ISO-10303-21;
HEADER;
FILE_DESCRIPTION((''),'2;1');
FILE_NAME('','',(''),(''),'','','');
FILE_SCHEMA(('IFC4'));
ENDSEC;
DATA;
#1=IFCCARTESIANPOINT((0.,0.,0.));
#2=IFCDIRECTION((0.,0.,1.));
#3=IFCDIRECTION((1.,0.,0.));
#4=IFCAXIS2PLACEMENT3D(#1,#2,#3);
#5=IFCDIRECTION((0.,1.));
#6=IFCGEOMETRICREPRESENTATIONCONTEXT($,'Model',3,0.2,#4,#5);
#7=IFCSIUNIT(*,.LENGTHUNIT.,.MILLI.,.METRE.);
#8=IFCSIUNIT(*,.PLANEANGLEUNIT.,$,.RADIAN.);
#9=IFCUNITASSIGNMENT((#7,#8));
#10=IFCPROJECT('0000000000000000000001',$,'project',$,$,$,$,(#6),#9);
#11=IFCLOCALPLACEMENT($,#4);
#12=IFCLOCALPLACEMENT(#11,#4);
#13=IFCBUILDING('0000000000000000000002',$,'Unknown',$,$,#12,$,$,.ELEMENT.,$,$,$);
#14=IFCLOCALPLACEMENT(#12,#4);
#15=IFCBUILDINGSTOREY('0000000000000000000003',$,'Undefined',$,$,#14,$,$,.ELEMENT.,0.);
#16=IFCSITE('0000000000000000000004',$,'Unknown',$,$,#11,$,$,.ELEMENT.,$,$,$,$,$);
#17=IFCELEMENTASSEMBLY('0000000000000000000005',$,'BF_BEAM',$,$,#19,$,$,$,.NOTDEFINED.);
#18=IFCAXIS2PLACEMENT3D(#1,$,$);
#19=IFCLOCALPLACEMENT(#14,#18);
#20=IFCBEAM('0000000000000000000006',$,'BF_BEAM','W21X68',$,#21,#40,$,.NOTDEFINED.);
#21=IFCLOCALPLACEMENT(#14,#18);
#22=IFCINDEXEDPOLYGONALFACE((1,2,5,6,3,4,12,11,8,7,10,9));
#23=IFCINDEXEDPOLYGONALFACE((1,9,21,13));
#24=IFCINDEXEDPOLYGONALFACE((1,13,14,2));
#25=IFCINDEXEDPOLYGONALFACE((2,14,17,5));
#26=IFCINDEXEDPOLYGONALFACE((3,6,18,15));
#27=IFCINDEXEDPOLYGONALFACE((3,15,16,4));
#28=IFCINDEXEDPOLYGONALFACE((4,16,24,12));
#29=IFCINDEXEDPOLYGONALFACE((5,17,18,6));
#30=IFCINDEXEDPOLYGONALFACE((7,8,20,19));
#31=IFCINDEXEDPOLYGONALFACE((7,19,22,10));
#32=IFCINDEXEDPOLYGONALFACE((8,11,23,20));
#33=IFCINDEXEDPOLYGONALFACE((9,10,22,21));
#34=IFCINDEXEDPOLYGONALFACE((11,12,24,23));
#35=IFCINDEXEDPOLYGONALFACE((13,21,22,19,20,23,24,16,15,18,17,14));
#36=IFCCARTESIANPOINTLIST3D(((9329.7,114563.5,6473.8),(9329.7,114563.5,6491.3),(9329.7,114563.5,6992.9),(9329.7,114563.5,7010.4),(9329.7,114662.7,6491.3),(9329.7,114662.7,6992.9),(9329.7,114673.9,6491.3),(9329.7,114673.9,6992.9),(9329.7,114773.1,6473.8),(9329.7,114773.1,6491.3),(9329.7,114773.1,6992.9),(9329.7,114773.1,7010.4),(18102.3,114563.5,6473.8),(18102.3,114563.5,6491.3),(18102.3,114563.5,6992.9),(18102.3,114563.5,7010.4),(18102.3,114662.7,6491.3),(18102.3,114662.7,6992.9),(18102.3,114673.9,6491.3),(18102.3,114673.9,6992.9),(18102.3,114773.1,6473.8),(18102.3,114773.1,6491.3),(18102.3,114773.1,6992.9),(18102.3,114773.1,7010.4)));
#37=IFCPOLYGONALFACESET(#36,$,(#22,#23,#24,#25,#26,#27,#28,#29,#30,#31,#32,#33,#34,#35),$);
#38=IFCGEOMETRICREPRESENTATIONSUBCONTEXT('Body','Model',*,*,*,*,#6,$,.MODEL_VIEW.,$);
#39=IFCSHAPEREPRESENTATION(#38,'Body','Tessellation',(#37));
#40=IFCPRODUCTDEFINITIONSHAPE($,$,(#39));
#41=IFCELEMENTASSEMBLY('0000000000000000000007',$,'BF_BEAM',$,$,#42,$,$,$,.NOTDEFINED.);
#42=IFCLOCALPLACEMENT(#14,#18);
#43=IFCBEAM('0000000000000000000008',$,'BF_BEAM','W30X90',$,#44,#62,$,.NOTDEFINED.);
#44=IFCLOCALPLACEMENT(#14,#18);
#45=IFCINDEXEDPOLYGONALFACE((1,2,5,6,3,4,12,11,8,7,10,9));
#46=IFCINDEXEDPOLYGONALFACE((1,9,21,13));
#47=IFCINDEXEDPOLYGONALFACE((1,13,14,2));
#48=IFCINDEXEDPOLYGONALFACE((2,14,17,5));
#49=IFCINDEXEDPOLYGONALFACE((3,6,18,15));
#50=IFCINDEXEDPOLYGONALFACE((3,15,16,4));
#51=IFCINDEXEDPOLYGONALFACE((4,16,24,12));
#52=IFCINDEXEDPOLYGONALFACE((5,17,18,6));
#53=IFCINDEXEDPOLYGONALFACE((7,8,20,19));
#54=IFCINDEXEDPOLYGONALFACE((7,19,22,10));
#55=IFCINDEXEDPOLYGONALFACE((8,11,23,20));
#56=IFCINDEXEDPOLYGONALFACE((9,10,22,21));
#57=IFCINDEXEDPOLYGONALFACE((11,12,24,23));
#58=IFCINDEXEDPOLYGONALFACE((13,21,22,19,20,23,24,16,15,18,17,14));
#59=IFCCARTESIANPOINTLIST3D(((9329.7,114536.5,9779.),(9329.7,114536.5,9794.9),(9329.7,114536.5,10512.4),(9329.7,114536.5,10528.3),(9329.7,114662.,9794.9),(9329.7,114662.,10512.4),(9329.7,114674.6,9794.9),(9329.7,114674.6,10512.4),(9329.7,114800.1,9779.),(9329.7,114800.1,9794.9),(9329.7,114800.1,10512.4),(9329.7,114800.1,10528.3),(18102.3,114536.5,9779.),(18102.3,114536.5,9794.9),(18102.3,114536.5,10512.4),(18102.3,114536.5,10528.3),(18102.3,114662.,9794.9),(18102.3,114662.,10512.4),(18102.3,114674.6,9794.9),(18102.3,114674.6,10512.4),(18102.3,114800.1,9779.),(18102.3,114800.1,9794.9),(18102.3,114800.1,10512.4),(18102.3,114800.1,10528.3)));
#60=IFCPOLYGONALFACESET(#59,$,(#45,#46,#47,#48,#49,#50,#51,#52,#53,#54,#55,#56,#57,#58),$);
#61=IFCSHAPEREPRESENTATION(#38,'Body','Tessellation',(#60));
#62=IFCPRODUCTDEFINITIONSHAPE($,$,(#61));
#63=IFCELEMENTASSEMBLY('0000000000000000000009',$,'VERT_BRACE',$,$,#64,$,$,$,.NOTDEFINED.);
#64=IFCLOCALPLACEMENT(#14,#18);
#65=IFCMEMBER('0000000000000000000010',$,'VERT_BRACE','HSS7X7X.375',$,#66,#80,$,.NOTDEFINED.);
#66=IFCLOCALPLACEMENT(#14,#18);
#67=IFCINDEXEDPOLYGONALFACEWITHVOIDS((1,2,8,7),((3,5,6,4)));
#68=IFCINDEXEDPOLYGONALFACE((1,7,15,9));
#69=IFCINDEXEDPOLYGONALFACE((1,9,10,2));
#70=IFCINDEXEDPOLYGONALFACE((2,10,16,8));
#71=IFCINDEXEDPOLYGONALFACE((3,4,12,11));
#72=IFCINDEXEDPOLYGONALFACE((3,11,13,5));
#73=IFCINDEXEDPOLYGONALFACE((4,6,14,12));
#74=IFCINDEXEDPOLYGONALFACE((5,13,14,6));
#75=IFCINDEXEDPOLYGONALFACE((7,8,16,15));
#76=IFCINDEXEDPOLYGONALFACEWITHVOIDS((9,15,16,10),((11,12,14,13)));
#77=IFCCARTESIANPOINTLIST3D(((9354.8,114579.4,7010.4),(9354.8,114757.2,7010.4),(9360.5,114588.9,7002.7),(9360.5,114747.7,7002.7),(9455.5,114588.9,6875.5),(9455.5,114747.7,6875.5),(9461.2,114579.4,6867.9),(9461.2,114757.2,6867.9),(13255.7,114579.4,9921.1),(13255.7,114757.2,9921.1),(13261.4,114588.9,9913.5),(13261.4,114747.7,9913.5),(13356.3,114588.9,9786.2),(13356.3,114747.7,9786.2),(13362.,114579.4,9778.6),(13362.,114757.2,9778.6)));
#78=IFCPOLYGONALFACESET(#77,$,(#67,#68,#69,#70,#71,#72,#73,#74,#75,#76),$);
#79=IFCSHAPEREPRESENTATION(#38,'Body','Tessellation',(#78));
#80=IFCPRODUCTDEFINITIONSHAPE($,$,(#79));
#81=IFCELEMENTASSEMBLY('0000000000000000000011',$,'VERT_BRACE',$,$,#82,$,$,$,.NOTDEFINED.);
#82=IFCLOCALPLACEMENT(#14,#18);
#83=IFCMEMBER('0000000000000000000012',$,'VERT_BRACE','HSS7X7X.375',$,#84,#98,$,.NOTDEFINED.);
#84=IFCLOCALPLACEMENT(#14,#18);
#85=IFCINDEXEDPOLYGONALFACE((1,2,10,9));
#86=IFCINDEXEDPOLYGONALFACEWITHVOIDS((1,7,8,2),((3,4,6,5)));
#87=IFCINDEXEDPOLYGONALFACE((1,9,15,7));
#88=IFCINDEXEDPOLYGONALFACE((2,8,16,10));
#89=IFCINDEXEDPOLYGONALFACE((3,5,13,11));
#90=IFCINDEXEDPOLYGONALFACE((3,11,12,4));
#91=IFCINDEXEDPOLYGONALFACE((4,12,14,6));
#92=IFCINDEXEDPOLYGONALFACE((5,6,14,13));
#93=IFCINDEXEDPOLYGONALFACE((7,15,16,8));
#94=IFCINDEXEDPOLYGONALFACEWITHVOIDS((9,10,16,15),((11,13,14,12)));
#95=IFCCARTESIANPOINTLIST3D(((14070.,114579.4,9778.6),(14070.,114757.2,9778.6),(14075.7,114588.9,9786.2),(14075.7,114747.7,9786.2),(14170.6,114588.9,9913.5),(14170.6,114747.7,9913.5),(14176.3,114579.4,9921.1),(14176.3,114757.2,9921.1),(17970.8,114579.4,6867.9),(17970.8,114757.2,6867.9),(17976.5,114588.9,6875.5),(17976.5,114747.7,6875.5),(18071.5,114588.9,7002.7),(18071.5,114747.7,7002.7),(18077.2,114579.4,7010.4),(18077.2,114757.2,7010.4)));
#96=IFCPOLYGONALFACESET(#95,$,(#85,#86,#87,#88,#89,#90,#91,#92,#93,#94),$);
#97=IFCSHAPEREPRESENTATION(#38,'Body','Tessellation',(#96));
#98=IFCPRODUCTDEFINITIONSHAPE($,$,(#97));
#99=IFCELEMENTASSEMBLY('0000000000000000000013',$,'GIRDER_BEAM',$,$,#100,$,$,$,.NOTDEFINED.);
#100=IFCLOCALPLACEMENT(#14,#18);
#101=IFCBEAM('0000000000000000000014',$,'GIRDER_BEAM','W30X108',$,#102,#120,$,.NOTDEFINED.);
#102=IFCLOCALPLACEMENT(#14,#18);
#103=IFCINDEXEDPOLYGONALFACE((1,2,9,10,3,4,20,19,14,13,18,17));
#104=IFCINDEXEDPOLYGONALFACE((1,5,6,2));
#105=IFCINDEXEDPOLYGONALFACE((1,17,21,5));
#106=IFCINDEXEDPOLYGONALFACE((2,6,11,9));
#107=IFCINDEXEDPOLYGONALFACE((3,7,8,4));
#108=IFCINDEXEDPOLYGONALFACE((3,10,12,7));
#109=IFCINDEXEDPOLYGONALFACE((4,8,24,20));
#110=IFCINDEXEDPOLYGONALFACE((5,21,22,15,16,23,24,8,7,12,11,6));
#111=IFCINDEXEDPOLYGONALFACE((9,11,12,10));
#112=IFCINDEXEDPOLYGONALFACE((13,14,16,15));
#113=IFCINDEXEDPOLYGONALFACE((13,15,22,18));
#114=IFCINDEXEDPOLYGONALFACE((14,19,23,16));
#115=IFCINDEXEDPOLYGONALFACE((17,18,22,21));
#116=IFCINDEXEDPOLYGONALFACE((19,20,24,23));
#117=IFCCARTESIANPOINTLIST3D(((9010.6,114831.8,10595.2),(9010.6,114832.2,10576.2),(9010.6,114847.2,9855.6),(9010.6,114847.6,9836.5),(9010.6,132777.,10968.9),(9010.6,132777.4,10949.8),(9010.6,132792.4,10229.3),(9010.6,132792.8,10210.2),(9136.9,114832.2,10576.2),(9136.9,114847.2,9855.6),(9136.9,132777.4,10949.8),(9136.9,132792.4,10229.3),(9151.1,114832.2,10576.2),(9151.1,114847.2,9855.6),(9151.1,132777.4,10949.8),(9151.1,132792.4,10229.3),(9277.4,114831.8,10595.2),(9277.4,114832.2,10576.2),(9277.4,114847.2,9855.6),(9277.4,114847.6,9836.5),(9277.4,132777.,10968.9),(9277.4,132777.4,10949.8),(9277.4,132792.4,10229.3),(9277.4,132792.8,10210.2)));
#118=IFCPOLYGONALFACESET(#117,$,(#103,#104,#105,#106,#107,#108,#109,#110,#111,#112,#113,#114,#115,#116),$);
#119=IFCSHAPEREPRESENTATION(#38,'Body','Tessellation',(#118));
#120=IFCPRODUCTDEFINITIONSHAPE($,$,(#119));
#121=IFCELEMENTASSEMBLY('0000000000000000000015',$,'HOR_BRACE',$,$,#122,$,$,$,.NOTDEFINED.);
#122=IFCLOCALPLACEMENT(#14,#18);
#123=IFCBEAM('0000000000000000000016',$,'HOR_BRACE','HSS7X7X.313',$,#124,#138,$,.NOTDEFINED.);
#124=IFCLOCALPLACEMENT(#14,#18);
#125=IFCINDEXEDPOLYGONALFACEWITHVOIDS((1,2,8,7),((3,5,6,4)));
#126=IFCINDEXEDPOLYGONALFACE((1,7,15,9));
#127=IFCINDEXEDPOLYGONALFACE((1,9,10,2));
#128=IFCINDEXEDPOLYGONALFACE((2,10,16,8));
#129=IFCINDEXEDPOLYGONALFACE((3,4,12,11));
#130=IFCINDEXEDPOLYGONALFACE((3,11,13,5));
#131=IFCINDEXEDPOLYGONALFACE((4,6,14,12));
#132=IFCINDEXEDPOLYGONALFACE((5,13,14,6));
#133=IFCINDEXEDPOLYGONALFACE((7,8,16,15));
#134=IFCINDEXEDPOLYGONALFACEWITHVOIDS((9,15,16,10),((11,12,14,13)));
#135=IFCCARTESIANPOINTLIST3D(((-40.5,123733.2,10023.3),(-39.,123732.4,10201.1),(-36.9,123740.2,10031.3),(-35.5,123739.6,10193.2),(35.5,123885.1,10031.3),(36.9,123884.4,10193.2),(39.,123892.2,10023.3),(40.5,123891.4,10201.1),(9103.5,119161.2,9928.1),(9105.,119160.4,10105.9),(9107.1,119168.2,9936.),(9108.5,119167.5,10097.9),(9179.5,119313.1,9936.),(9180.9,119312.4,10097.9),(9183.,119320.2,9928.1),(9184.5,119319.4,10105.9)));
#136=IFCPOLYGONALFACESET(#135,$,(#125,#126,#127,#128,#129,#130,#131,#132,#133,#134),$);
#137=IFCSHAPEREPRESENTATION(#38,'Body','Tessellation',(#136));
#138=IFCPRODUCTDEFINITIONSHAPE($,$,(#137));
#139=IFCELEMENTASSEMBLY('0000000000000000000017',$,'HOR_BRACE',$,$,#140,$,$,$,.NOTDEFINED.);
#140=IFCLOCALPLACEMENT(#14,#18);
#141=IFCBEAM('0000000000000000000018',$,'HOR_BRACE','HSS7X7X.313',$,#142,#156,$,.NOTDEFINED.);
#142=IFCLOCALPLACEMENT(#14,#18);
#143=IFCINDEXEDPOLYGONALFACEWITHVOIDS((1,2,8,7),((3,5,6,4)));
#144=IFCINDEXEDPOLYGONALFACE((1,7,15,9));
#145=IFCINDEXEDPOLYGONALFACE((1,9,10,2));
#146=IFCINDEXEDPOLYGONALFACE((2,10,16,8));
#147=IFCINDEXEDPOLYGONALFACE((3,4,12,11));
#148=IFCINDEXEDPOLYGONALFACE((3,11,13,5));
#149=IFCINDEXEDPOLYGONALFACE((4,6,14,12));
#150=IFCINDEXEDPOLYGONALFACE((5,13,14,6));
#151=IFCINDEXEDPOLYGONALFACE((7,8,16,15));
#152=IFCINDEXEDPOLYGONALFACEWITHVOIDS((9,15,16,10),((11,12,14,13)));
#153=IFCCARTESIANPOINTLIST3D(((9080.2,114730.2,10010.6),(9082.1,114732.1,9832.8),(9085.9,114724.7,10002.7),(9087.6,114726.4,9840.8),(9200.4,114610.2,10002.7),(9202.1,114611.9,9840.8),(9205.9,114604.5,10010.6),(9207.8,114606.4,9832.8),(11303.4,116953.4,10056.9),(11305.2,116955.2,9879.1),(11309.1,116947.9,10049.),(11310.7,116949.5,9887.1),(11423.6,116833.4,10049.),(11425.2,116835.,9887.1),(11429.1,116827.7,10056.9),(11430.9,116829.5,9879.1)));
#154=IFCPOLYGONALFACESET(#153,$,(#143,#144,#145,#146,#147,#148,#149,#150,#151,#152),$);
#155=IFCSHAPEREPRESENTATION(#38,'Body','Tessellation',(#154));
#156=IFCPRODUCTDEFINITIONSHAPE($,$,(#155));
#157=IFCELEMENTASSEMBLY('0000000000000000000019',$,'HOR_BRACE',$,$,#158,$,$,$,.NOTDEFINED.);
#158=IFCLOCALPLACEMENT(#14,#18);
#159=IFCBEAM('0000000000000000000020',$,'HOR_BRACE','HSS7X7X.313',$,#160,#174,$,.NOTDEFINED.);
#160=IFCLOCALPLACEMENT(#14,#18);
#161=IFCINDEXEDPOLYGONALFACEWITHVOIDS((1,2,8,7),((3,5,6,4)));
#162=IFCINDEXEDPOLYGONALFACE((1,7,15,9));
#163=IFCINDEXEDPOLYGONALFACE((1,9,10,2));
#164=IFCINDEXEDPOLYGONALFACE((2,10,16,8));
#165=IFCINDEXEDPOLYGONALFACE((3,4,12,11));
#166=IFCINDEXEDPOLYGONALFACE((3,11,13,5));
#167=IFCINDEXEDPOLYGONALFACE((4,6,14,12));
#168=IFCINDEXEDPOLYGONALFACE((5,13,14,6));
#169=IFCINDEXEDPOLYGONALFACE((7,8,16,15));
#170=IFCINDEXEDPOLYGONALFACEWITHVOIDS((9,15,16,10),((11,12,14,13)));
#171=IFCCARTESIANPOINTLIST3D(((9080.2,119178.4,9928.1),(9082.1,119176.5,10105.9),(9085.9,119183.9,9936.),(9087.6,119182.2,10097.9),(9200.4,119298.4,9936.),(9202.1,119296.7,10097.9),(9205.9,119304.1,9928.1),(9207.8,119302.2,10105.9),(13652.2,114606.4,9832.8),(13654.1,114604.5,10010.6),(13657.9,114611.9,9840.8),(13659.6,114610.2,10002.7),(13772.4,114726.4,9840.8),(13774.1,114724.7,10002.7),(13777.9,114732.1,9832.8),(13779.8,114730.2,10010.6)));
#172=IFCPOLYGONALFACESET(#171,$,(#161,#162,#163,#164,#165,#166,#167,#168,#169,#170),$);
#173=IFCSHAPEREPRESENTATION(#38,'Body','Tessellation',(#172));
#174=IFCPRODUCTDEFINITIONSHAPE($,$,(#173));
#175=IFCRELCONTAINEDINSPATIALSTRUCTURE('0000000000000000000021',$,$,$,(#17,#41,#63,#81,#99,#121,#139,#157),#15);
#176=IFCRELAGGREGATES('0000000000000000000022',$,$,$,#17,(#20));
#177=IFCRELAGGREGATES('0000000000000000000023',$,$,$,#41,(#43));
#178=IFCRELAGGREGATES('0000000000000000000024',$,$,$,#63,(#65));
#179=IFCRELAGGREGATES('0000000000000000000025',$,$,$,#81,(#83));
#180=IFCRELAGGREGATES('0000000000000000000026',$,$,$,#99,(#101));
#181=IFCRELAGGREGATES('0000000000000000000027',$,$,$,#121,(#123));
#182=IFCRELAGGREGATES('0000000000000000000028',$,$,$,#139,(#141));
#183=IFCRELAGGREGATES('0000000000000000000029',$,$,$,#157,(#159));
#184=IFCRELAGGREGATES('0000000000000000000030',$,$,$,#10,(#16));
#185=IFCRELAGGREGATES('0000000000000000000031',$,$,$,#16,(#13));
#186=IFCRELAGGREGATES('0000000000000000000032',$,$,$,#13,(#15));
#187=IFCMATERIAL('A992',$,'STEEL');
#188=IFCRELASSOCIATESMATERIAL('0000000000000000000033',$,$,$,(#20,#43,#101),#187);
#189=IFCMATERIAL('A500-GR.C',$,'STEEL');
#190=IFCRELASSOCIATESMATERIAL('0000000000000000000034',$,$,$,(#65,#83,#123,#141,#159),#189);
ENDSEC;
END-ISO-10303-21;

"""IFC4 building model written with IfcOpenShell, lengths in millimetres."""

from ifc_helpers import new_model, si_unit, direction, frame, origin_with_axes, place, context, subcontext, project, spatial, line, indexed_curve, outline, extrude, material, element, aggregate, save


model = new_model("IFC4")

# Units and contexts
model_context = context("Model", 3, precision=0.2, world=origin_with_axes(), true_north=direction((0.0, 1.0)))
body_context = subcontext(model_context, "Body", "Model", "MODEL_VIEW")
ifc_project = project(units=[si_unit("LENGTHUNIT", "METRE", prefix="MILLI"), si_unit("PLANEANGLEUNIT", "RADIAN")], contexts=[model_context])

# Site, building, storey
site_placement = place(None, origin_with_axes())
site = spatial("IfcSite", under=ifc_project, at=site_placement, Name="Unknown", CompositionType="ELEMENT")
building_placement = place(site_placement, origin_with_axes())
building = spatial("IfcBuilding", under=site, at=building_placement, Name="Unknown", CompositionType="ELEMENT")
storey_placement = place(building_placement, origin_with_axes())
storey = spatial("IfcBuildingStorey", under=building, at=storey_placement, Name="Undefined", CompositionType="ELEMENT", Elevation=0.0)

# Shared definitions
ifc_material_1 = material(Name="A992", Category="STEEL")

# Element assemblies, beams
assembly_1_placement = place(storey_placement, frame((9329.7, 114668.3, 6742.1), z_axis=(0.0, -1.0, 0.0), x_axis=(1.0, 0.0, 0.0)))
assembly_1 = element("IfcElementAssembly", 1, at=assembly_1_placement, inside=storey, Name="BF_BEAM", PredefinedType="NOTDEFINED")
beam_1_placement = place(assembly_1_placement, origin_with_axes())
beam_1 = element("IfcBeam", 2, at=beam_1_placement, material=ifc_material_1, Name="BF_BEAM", Description="W21X68", PredefinedType="NOTDEFINED", context=body_context, shape_type="SolidModel", body=[
    extrude(outline(indexed_curve([(-104.8, -268.3), (104.8, -268.3), (104.8, -250.8), (5.6, -250.8), (5.6, 250.8), (104.8, 250.8), (104.8, 268.3), (-104.8, 268.3), (-104.8, 250.8), (-5.6, 250.8), (-5.6, -250.8), (-104.8, -250.8)], segments=[line(1, 2, 3, 4, 5, 6, 7, 8, 9, 10, 11, 12, 1)])), frame((0.0, 0.0, 0.0), z_axis=(-1.0, 0.0, 0.0), x_axis=(0.0, 0.0, 1.0)), (0.0, 0.0, -1.0), 8772.5),
])
aggregate(assembly_1, [beam_1])
assembly_2_placement = place(storey_placement, frame((9329.7, 114668.3, 10153.6), z_axis=(0.0, -1.0, 0.0), x_axis=(1.0, 0.0, 0.0)))
assembly_2 = element("IfcElementAssembly", 3, at=assembly_2_placement, inside=storey, Name="BF_BEAM", PredefinedType="NOTDEFINED")
beam_2_placement = place(assembly_2_placement, origin_with_axes())
beam_2 = element("IfcBeam", 4, at=beam_2_placement, material=ifc_material_1, Name="BF_BEAM", Description="W30X90", PredefinedType="NOTDEFINED", context=body_context, shape_type="SolidModel", body=[
    extrude(outline(indexed_curve([(-131.8, -374.6), (131.8, -374.6), (131.8, -358.8), (6.3, -358.8), (6.3, 358.8), (131.8, 358.8), (131.8, 374.6), (-131.8, 374.6), (-131.8, 358.8), (-6.3, 358.8), (-6.3, -358.8), (-131.8, -358.8)], segments=[line(1, 2, 3, 4, 5, 6, 7, 8, 9, 10, 11, 12, 1)])), frame((0.0, 0.0, 0.0), z_axis=(-1.0, 0.0, 0.0), x_axis=(0.0, 0.0, 1.0)), (0.0, 0.0, -1.0), 8772.5),
])
aggregate(assembly_2, [beam_2])

# Element assemblies, members
assembly_3_placement = place(storey_placement, frame((9408.0, 114668.3, 6939.1), z_axis=(0.0, -1.0, 0.0), x_axis=(0.801467, 0.0, 0.598039)))
assembly_3 = element("IfcElementAssembly", 5, at=assembly_3_placement, inside=storey, Name="VERT_BRACE", PredefinedType="NOTDEFINED")
ifc_material_2 = material(Name="A500-GR.C", Category="STEEL")
member_1_placement = place(assembly_3_placement, origin_with_axes())
member_1 = element("IfcMember", 6, at=member_1_placement, material=ifc_material_2, Name="VERT_BRACE", Description="HSS7X7X.375", PredefinedType="NOTDEFINED", context=body_context, shape_type="SolidModel", body=[
    extrude(outline(indexed_curve([(-88.9, -88.9), (88.9, -88.9), (88.9, 88.9), (-88.9, 88.9)], segments=[line(1, 2, 3, 4, 1)]), holes=[indexed_curve([(-79.4, -79.4), (-79.4, 79.4), (79.4, 79.4), (79.4, -79.4)], segments=[line(1, 2, 3, 4, 1)])]), frame((0.0, 0.0, 0.0), z_axis=(-1.0, 0.0, 0.0), x_axis=(0.0, 0.0, 1.0)), (0.0, 0.0, -1.0), 4867.1),
])
aggregate(assembly_3, [member_1])
assembly_4_placement = place(storey_placement, frame((18024.0, 114668.3, 6939.1), z_axis=(0.0, 1.0, 0.0), x_axis=(-0.801467, 0.0, 0.598039)))
assembly_4 = element("IfcElementAssembly", 7, at=assembly_4_placement, inside=storey, Name="VERT_BRACE", PredefinedType="NOTDEFINED")
member_2_placement = place(assembly_4_placement, origin_with_axes())
member_2 = element("IfcMember", 8, at=member_2_placement, material=ifc_material_2, Name="VERT_BRACE", Description="HSS7X7X.375", PredefinedType="NOTDEFINED", context=body_context, shape_type="SolidModel", body=[
    extrude(outline(indexed_curve([(-88.9, -88.9), (88.9, -88.9), (88.9, 88.9), (-88.9, 88.9)], segments=[line(1, 2, 3, 4, 1)]), holes=[indexed_curve([(-79.4, -79.4), (-79.4, 79.4), (79.4, 79.4), (79.4, -79.4)], segments=[line(1, 2, 3, 4, 1)])]), frame((0.0, 0.0, 0.0), z_axis=(-1.0, 0.0, 0.0), x_axis=(0.0, 0.0, 1.0)), (0.0, 0.0, -1.0), 4867.1),
])
aggregate(assembly_4, [member_2])

# Element assemblies, beams
assembly_5_placement = place(storey_placement, frame((9144.0, 114839.7, 10215.9), z_axis=(1.0, 0.0, 0.0), x_axis=(0.0, 0.999783, 0.020819)))
assembly_5 = element("IfcElementAssembly", 9, at=assembly_5_placement, inside=storey, Name="GIRDER_BEAM", PredefinedType="NOTDEFINED")
beam_3_placement = place(assembly_5_placement, origin_with_axes())
beam_3 = element("IfcBeam", 10, at=beam_3_placement, material=ifc_material_1, Name="GIRDER_BEAM", Description="W30X108", PredefinedType="NOTDEFINED", context=body_context, shape_type="SolidModel", body=[
    extrude(outline(indexed_curve([(-133.3, -379.4), (133.3, -379.4), (133.3, -360.4), (7.1, -360.4), (7.1, 360.4), (133.3, 360.4), (133.3, 379.4), (-133.3, 379.4), (-133.3, 360.4), (-7.1, 360.4), (-7.1, -360.4), (-133.3, -360.4)], segments=[line(1, 2, 3, 4, 5, 6, 7, 8, 9, 10, 11, 12, 1)])), frame((0.0, 0.0, 0.0), z_axis=(-1.0, 0.0, 0.0), x_axis=(0.0, 0.0, 1.0)), (0.0, 0.0, -1.0), 17949.1),
])
aggregate(assembly_5, [beam_3])
assembly_6_placement = place(storey_placement, frame((9144.0, 119240.3, 10017.0), z_axis=(0.447214, 0.894427, 0.0), x_axis=(-0.894388, 0.447194, 0.009317)))
assembly_6 = element("IfcElementAssembly", 11, at=assembly_6_placement, inside=storey, Name="HOR_BRACE", PredefinedType="NOTDEFINED")
beam_4_placement = place(assembly_6_placement, origin_with_axes())
beam_4 = element("IfcBeam", 12, at=beam_4_placement, material=ifc_material_2, Name="HOR_BRACE", Description="HSS7X7X.313", PredefinedType="NOTDEFINED", context=body_context, shape_type="SolidModel", body=[
    extrude(outline(indexed_curve([(-88.9, -88.9), (88.9, -88.9), (88.9, 88.9), (-88.9, 88.9)], segments=[line(1, 2, 3, 4, 1)]), holes=[indexed_curve([(-81.0, -81.0), (-81.0, 81.0), (81.0, 81.0), (81.0, -81.0)], segments=[line(1, 2, 3, 4, 1)])]), frame((0.0, 0.0, 0.0), z_axis=(-1.0, 0.0, 0.0), x_axis=(0.0, 0.0, 1.0)), (0.0, 0.0, -1.0), 10223.7),
])
aggregate(assembly_6, [beam_4])
assembly_7_placement = place(storey_placement, frame((9144.0, 114668.3, 9921.7), z_axis=(0.707107, -0.707107, 0.0), x_axis=(0.70703, 0.70703, 0.01473)))
assembly_7 = element("IfcElementAssembly", 13, at=assembly_7_placement, inside=storey, Name="HOR_BRACE", PredefinedType="NOTDEFINED")
beam_5_placement = place(assembly_7_placement, origin_with_axes())
beam_5 = element("IfcBeam", 14, at=beam_5_placement, material=ifc_material_2, Name="HOR_BRACE", Description="HSS7X7X.313", PredefinedType="NOTDEFINED", context=body_context, shape_type="SolidModel", body=[
    extrude(outline(indexed_curve([(-88.9, -88.9), (88.9, -88.9), (88.9, 88.9), (-88.9, 88.9)], segments=[line(1, 2, 3, 4, 1)]), holes=[indexed_curve([(-81.0, -81.0), (-81.0, 81.0), (81.0, 81.0), (81.0, -81.0)], segments=[line(1, 2, 3, 4, 1)])]), frame((0.0, 0.0, 0.0), z_axis=(-1.0, 0.0, 0.0), x_axis=(0.0, 0.0, 1.0)), (0.0, 0.0, -1.0), 3144.3),
])
aggregate(assembly_7, [beam_5])
assembly_8_placement = place(storey_placement, frame((13716.0, 114668.3, 9921.7), z_axis=(0.707107, 0.707107, 0.0), x_axis=(-0.70703, 0.70703, 0.01473)))
assembly_8 = element("IfcElementAssembly", 15, at=assembly_8_placement, inside=storey, Name="HOR_BRACE", PredefinedType="NOTDEFINED")
beam_6_placement = place(assembly_8_placement, origin_with_axes())
beam_6 = element("IfcBeam", 16, at=beam_6_placement, material=ifc_material_2, Name="HOR_BRACE", Description="HSS7X7X.313", PredefinedType="NOTDEFINED", context=body_context, shape_type="SolidModel", body=[
    extrude(outline(indexed_curve([(-88.9, -88.9), (88.9, -88.9), (88.9, 88.9), (-88.9, 88.9)], segments=[line(1, 2, 3, 4, 1)]), holes=[indexed_curve([(-81.0, -81.0), (-81.0, 81.0), (81.0, 81.0), (81.0, -81.0)], segments=[line(1, 2, 3, 4, 1)])]), frame((0.0, 0.0, 0.0), z_axis=(-1.0, 0.0, 0.0), x_axis=(0.0, 0.0, 1.0)), (0.0, 0.0, -1.0), 6466.5),
])
aggregate(assembly_8, [beam_6])

save(model, "model.ifc")
